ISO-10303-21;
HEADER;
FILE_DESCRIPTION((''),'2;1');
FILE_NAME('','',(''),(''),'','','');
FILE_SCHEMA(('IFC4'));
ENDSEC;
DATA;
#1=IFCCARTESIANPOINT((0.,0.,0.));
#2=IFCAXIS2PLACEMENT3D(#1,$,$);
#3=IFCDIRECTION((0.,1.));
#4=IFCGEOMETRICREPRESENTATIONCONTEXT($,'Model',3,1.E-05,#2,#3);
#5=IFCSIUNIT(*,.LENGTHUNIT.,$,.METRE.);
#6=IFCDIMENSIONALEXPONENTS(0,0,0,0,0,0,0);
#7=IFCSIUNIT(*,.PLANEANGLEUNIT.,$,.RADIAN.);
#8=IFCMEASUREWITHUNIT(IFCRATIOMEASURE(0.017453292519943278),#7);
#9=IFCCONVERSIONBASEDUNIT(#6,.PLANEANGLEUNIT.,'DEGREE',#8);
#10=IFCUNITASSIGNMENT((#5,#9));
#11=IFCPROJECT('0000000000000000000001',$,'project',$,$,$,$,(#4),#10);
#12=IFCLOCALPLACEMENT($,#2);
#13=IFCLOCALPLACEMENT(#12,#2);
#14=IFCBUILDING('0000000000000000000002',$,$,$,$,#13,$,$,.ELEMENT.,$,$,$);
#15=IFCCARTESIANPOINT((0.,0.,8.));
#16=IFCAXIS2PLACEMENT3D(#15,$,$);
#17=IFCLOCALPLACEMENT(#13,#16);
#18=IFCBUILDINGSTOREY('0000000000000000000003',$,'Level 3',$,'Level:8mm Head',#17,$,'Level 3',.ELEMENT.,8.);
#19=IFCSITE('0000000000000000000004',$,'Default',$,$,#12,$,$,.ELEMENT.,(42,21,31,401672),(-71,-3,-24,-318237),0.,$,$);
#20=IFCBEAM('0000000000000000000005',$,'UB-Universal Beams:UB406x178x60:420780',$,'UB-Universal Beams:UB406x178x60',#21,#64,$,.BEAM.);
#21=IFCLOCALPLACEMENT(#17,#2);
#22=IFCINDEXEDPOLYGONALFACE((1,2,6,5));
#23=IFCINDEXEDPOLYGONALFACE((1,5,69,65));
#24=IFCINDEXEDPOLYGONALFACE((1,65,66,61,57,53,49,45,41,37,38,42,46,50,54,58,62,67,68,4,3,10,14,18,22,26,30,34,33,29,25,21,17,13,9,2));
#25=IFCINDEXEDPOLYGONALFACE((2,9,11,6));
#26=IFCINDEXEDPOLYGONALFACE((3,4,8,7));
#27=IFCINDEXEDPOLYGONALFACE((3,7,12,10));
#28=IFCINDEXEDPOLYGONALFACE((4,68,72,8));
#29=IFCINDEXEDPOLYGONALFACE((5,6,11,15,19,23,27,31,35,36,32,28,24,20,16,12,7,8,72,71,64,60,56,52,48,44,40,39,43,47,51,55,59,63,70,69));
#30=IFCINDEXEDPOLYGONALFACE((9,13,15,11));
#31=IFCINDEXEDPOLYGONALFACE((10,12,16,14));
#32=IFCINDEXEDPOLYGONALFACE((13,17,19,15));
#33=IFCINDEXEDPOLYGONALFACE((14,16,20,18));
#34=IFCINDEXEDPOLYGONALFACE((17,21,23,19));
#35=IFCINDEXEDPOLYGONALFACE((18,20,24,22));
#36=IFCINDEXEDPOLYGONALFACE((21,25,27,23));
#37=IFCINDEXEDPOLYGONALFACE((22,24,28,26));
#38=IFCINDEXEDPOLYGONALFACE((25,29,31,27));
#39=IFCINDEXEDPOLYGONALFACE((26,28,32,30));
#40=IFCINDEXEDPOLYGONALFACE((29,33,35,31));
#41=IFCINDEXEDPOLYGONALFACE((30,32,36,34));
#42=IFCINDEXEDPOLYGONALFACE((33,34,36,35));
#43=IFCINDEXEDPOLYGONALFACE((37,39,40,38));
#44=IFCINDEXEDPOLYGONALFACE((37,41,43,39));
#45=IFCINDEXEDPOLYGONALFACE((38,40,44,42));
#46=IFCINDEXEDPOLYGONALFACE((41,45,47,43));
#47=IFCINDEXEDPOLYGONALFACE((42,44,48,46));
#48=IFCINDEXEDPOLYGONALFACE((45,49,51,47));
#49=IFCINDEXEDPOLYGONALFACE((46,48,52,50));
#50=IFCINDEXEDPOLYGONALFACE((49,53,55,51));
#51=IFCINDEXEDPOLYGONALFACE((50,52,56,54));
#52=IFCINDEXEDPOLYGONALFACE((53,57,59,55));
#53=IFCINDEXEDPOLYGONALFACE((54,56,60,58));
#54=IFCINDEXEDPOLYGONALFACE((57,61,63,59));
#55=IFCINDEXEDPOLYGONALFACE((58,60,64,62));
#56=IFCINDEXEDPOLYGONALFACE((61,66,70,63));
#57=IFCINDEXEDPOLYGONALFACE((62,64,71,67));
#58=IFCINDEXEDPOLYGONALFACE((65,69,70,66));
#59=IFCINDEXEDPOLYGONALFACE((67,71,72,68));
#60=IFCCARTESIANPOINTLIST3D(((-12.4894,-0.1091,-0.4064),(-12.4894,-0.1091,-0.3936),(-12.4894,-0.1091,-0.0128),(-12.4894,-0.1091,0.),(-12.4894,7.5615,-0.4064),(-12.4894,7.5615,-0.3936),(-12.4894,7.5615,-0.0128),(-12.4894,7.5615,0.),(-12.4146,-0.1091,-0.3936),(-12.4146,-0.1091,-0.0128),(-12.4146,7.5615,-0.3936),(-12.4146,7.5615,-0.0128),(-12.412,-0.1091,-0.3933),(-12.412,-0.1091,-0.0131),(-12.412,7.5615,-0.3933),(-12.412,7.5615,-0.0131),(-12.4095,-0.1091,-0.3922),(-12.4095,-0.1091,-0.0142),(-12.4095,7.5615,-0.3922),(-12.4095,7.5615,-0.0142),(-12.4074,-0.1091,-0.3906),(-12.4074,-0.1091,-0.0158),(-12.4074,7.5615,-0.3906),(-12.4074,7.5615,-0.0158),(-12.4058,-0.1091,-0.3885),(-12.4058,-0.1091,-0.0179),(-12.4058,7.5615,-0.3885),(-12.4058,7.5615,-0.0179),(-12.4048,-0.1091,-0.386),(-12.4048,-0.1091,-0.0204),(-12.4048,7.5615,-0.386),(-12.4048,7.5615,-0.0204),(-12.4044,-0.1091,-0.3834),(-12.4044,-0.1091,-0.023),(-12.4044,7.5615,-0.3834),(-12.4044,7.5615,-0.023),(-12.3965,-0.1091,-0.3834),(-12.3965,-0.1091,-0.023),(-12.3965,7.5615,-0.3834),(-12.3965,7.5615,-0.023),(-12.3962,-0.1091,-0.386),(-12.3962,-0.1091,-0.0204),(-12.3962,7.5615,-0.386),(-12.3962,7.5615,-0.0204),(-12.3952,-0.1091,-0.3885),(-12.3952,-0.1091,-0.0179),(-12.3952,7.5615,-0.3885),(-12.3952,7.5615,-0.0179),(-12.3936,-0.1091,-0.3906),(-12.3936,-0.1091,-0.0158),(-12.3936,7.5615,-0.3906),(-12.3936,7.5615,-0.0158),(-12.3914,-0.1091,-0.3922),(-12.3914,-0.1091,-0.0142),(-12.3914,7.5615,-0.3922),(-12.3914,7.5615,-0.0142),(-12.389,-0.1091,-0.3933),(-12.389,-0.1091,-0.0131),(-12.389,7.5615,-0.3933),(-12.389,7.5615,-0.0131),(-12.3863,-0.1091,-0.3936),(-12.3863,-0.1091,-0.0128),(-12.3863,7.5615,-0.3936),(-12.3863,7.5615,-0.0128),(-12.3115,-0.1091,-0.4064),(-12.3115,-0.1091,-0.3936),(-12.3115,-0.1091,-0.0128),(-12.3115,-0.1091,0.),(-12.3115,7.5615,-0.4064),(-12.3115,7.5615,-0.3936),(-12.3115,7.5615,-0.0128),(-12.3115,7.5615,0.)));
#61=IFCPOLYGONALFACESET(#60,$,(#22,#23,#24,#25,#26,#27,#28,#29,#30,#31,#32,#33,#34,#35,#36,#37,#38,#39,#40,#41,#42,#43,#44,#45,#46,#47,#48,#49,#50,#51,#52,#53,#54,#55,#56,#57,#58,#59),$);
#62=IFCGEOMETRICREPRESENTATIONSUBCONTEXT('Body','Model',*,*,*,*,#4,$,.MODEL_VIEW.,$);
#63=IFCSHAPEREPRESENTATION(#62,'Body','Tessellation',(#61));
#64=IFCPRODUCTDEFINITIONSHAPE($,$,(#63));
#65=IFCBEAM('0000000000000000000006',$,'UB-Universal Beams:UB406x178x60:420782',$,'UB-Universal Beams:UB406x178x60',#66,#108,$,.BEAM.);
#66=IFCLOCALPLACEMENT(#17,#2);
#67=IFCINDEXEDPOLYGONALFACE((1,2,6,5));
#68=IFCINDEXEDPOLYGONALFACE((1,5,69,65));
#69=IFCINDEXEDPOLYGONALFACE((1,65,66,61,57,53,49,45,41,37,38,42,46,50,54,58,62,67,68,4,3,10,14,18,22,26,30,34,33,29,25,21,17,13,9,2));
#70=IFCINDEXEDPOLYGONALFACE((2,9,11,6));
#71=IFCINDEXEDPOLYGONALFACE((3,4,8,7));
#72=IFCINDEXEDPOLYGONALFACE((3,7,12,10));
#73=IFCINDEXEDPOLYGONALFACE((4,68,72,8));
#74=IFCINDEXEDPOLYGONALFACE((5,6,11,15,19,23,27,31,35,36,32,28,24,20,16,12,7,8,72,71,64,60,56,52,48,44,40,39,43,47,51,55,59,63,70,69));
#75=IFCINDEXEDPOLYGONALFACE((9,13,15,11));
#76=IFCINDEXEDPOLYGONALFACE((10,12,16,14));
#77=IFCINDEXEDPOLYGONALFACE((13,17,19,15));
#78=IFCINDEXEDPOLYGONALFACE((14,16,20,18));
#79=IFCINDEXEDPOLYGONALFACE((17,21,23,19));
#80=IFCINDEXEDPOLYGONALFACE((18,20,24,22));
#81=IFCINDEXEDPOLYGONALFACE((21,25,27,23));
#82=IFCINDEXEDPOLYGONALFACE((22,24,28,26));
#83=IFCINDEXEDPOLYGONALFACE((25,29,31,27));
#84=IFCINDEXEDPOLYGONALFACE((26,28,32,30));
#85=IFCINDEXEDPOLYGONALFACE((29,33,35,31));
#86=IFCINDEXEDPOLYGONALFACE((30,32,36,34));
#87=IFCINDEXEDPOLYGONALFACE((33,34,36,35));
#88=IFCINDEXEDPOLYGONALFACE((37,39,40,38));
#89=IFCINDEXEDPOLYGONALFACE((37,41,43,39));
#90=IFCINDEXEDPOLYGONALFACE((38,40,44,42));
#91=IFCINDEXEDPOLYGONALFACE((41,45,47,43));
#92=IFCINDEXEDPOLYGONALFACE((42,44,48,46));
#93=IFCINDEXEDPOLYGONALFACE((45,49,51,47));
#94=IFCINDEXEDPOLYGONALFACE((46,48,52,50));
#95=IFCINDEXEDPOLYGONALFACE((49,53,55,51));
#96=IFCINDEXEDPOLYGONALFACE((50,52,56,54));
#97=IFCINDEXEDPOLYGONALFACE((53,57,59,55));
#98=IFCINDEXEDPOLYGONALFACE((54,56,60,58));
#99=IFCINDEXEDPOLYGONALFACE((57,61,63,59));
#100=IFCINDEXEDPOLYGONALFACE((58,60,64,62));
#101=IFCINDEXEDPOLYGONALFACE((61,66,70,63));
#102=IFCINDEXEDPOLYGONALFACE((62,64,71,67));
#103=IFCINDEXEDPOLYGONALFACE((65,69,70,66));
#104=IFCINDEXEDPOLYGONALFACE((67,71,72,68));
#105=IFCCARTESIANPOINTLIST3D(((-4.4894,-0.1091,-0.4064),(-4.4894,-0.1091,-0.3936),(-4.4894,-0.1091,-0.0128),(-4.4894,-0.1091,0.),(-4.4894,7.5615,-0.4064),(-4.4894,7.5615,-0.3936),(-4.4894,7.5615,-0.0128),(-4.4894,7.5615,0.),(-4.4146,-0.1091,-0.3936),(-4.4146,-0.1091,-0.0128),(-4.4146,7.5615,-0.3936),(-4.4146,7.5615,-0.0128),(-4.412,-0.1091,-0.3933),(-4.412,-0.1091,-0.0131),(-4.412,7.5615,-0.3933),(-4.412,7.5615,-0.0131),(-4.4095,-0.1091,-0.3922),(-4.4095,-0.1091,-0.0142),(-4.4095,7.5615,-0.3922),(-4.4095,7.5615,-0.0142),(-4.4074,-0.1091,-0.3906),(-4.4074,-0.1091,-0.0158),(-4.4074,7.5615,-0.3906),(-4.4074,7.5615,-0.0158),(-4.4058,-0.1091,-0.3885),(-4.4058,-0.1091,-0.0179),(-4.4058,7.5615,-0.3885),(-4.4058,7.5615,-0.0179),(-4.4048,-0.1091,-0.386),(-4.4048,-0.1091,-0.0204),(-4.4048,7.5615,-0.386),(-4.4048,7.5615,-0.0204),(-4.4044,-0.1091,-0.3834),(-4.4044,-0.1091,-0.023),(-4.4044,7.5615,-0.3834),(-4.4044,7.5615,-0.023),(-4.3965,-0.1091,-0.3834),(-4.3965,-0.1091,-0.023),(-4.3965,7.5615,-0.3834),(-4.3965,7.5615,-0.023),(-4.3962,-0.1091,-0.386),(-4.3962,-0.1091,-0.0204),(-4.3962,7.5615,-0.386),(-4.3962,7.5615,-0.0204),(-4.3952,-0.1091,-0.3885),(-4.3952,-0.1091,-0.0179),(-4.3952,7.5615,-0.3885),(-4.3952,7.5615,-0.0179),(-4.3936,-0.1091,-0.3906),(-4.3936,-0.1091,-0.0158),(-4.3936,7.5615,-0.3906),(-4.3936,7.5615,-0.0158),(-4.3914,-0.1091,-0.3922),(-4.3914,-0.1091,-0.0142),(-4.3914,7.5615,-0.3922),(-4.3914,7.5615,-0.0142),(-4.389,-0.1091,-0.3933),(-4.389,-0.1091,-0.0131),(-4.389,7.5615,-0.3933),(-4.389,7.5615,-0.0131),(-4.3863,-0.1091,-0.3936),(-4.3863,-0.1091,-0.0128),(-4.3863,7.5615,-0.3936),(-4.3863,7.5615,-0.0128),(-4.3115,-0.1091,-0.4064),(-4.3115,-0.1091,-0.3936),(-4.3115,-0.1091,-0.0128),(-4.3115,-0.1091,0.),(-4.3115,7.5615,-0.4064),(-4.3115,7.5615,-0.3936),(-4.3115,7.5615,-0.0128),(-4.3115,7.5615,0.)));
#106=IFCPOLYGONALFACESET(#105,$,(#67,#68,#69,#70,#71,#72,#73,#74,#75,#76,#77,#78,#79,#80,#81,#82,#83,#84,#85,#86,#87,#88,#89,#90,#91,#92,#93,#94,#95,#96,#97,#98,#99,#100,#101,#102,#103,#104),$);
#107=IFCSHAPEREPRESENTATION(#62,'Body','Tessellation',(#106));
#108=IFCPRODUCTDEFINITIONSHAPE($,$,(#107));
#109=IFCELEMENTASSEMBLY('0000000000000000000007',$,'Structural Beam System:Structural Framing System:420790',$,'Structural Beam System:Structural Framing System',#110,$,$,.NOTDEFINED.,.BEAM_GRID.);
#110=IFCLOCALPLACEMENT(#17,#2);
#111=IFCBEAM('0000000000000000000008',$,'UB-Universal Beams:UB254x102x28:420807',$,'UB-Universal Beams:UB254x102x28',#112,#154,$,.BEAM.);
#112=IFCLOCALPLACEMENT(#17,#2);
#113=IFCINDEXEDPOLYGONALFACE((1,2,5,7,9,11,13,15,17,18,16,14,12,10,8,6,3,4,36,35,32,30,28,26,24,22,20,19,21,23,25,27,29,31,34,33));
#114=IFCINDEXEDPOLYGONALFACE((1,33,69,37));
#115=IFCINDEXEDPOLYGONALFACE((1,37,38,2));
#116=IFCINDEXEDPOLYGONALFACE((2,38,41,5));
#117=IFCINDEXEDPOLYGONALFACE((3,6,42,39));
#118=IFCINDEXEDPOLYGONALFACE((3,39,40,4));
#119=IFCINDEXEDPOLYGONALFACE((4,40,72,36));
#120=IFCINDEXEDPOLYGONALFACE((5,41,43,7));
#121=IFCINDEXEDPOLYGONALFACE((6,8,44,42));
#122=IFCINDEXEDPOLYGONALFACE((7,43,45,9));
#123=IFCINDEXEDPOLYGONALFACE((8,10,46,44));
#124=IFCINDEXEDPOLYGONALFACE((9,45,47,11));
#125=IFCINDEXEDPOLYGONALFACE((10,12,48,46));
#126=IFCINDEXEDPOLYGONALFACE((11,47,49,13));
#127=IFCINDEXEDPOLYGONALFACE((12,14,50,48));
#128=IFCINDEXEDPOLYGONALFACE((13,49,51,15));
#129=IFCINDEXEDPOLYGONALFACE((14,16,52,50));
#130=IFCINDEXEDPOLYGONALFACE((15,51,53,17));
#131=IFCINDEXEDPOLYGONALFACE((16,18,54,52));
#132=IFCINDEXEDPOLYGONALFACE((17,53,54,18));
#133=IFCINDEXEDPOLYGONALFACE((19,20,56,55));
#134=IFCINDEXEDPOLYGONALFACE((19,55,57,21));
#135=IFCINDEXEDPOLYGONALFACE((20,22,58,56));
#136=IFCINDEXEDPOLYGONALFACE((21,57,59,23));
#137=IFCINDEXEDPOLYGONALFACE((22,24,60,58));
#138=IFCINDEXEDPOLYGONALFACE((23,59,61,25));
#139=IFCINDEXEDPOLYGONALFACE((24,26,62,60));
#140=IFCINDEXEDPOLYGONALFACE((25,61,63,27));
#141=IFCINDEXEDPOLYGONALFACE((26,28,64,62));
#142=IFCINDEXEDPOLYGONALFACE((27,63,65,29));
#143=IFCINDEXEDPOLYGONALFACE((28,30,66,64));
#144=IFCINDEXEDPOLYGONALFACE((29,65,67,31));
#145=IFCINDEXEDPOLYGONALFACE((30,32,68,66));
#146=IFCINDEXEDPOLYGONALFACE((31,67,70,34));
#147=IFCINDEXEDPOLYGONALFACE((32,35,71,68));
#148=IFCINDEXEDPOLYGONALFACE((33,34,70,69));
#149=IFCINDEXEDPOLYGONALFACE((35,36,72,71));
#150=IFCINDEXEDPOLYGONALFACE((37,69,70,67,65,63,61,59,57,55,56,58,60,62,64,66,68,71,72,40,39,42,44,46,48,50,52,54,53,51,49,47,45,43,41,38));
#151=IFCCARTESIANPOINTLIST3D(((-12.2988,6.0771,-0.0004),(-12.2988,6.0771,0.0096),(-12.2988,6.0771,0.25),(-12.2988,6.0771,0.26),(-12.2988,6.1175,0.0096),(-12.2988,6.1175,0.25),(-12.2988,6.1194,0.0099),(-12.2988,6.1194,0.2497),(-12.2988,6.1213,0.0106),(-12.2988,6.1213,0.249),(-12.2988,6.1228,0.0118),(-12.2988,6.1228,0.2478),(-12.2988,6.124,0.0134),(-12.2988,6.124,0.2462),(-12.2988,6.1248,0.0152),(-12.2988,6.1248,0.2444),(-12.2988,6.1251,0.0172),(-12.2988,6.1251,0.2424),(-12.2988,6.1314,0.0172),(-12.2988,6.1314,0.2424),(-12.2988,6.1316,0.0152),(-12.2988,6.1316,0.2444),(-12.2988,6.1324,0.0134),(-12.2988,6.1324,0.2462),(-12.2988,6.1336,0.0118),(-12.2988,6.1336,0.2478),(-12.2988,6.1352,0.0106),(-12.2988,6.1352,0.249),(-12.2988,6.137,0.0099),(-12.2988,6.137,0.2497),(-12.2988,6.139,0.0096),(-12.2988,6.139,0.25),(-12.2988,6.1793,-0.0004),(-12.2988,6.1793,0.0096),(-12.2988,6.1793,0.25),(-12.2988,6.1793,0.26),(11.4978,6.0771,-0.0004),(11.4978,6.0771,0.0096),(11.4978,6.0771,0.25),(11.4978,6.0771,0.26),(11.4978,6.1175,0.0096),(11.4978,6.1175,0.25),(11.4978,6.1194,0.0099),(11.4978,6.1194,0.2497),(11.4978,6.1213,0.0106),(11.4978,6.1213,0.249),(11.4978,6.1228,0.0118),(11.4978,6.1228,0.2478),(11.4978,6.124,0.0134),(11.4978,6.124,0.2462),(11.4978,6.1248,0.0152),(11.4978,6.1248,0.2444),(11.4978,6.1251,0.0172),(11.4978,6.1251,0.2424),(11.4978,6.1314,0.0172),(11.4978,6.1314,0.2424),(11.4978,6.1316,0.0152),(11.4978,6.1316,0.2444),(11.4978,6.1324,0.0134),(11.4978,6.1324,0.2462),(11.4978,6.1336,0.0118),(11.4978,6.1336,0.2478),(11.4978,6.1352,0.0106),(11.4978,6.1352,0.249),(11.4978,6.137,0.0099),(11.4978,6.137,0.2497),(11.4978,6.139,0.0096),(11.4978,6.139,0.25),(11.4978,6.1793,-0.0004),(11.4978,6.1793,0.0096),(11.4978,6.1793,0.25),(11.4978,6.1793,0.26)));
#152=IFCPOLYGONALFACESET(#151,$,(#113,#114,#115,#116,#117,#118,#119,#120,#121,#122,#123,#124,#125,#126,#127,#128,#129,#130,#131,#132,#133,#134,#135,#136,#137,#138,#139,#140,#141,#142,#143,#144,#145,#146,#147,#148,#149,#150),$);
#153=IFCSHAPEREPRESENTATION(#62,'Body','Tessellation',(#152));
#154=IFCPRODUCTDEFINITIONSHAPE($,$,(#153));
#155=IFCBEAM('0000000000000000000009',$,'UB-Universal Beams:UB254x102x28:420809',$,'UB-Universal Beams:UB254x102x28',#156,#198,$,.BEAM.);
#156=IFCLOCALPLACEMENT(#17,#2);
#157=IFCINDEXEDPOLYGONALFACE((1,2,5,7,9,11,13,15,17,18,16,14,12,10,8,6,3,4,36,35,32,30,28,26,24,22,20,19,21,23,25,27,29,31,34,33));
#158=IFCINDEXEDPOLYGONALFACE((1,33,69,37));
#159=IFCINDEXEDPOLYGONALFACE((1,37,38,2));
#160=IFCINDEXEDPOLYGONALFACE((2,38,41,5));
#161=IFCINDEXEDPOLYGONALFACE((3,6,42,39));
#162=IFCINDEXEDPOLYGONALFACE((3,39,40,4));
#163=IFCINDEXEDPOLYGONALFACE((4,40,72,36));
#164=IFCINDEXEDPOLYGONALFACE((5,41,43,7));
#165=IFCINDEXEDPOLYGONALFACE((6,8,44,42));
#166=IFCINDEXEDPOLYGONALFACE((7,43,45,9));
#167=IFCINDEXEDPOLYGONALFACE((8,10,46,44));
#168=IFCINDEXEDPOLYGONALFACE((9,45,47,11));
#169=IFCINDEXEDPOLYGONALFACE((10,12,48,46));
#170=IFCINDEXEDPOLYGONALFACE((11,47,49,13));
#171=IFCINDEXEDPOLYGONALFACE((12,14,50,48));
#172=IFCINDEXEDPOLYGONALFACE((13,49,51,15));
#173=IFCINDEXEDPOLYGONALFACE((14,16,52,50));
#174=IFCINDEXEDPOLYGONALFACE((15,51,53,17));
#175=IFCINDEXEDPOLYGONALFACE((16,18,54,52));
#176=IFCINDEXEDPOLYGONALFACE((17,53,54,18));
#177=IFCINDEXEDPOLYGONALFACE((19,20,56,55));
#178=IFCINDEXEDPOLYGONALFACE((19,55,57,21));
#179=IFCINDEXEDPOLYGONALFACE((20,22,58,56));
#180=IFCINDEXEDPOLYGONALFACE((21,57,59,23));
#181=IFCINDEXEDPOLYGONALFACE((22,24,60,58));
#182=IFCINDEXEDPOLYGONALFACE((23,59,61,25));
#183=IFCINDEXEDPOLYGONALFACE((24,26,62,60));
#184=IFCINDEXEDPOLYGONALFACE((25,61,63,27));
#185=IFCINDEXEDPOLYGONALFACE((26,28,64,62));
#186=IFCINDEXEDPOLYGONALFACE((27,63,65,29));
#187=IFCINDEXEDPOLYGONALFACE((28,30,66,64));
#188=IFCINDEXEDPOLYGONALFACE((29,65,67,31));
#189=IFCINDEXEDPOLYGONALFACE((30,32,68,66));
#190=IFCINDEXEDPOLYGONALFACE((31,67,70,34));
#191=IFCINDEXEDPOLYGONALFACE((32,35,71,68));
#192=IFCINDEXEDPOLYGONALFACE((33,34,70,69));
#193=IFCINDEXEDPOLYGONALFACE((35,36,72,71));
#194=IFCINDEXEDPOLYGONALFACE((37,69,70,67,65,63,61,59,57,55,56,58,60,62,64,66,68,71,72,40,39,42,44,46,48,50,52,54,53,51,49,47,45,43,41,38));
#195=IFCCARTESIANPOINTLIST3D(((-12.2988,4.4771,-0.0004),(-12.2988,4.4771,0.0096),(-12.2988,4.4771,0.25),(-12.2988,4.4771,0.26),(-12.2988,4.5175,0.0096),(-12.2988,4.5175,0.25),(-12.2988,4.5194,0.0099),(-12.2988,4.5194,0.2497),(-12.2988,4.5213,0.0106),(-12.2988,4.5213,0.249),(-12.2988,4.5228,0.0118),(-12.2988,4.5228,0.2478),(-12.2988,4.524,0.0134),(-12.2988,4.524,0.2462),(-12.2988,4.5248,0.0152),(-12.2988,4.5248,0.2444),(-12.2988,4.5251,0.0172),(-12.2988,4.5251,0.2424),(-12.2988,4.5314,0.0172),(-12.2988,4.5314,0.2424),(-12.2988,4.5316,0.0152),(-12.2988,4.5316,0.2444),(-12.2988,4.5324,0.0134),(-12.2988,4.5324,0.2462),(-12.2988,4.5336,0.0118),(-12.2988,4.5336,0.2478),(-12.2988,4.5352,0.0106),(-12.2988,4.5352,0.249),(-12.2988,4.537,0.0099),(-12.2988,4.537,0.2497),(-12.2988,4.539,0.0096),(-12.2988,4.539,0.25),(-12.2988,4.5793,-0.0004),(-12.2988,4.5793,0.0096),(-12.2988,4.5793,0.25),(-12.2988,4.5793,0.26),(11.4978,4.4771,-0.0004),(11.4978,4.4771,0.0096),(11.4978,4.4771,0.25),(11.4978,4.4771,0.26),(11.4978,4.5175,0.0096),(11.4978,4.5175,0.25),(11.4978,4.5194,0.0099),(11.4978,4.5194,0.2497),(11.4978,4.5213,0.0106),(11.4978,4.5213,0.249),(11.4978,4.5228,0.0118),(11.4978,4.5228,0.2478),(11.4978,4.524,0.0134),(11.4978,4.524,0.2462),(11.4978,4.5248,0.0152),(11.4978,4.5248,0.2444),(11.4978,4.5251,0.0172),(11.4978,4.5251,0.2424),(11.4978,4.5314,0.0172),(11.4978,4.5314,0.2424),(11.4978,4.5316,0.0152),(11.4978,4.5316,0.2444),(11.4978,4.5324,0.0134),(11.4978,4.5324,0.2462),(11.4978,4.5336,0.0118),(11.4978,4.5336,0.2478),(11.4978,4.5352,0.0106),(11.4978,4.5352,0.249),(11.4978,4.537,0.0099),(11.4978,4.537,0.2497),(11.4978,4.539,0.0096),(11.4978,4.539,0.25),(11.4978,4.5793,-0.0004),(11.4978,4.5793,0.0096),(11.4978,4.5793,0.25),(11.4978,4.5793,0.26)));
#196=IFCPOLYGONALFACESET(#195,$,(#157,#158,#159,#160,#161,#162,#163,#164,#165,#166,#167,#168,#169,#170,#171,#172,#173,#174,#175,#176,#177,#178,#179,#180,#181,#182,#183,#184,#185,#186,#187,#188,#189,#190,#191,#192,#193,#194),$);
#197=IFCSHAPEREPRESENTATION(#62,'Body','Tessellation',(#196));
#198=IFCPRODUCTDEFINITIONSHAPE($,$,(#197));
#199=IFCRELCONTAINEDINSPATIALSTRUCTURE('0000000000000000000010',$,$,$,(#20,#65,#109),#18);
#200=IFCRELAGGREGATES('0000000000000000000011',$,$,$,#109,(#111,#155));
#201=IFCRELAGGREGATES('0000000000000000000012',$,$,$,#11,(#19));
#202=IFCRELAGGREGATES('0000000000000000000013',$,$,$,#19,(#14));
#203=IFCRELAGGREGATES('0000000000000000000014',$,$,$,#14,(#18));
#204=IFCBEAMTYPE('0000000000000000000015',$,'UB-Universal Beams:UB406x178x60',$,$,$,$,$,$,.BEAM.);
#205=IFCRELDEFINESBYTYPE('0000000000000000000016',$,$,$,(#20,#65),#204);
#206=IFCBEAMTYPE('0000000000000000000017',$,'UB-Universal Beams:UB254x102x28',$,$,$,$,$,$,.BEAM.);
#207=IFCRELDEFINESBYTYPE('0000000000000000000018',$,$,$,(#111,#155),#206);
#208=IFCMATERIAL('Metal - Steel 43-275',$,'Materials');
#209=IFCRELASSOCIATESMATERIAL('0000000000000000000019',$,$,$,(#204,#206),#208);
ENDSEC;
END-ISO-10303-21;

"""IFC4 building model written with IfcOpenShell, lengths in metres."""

from ifc_helpers import new_model, entity, si_unit, converted_unit, direction, frame, frame_2d, origin, place, context, subcontext, project, spatial, i_section, extrude, source, transform, mapped, material, material_profile, profile_set, type_object, type_shapes, element, aggregate, save


model = new_model("IFC4")

# Units and contexts
model_context = context("Model", 3, precision=1e-05, world=origin(), true_north=direction((0.0, 1.0)))
body_context = subcontext(model_context, "Body", "Model", "MODEL_VIEW")
ifc_project = project(units=[si_unit("LENGTHUNIT", "METRE"), converted_unit("PLANEANGLEUNIT", "DEGREE", entity("IfcRatioMeasure", 0.017453292519943278), si_unit("PLANEANGLEUNIT", "RADIAN"), dimensions=[0, 0, 0, 0, 0, 0, 0])], contexts=[model_context])

# Site, building, storey
site_placement = place(None, origin())
site = spatial("IfcSite", under=ifc_project, at=site_placement, Name="Default", CompositionType="ELEMENT", RefLatitude=(42, 21, 31, 401672), RefLongitude=(-71, -3, -24, -318237), RefElevation=0.0)
building_placement = place(site_placement, origin())
building = spatial("IfcBuilding", under=site, at=building_placement, CompositionType="ELEMENT")
storey_placement = place(building_placement, frame((0.0, 0.0, 8.0)))
storey = spatial("IfcBuildingStorey", under=building, at=storey_placement, Name="Level 3", ObjectType="Level:8mm Head", LongName="Level 3", CompositionType="ELEMENT", Elevation=8.0)

# Beams
ifc_material_1 = material(Name="Metal - Steel 43-275", Category="Materials")
ifc_material_profile_1 = material_profile(ifc_material_1, i_section(OverallWidth=0.1779, OverallDepth=0.4064, WebThickness=0.0079, FlangeThickness=0.0128, FilletRadius=0.0102, at=frame_2d((0.0, 0.0), x_axis=(0.0, 1.0))), Name="UB406x178x60")
ifc_profile_set_1 = profile_set([ifc_material_profile_1], Name="UB406x178x60")
beam_type_1 = type_object("IfcBeamType", Name="UB-Universal Beams:UB406x178x60", PredefinedType="BEAM", material=ifc_profile_set_1)
shared_shape_1 = source(origin(), body_context, "Body", "SweptSolid", [
    extrude(i_section(OverallWidth=0.1779, OverallDepth=0.4064, WebThickness=0.0079, FlangeThickness=0.0128, FilletRadius=0.0102, at=frame_2d((0.0, 0.0), x_axis=(0.0, 1.0))), frame((-3.8373, 0.0, 0.0), z_axis=(1.0, 0.0, 0.0), x_axis=(0.0, 0.0, -1.0)), (0.0, 0.0, 1.0), 7.6706),
])
type_shapes(beam_type_1, [shared_shape_1])
for number, where, z_axis, x_axis, name in (
    (1, (-12.4005, 3.7282, -0.2032), (0.0, 0.0, 1.0), (0.0, 1.0, 0.0), "UB-Universal Beams:UB406x178x60:420780"),
    (2, (-4.4005, 3.7282, -0.2032), (0.0, 0.0, 1.0), (0.0, 1.0, 0.0), "UB-Universal Beams:UB406x178x60:420782"),
):
    element("IfcBeam", number, at=place(storey_placement, frame(where, z_axis=z_axis, x_axis=x_axis)), inside=storey, type_object=beam_type_1, Name=name, ObjectType="UB-Universal Beams:UB406x178x60", PredefinedType="BEAM", context=body_context, shape_type="MappedRepresentation", body=[
        mapped(shared_shape_1, transform((0.0, 0.0, 0.0), scale=1.0)),
    ])

# Element assembly, beams
assembly_placement = place(storey_placement, origin())
assembly = element("IfcElementAssembly", 3, at=assembly_placement, inside=storey, Name="Structural Beam System:Structural Framing System:420790", ObjectType="Structural Beam System:Structural Framing System", AssemblyPlace="NOTDEFINED", PredefinedType="BEAM_GRID")
ifc_material_profile_2 = material_profile(ifc_material_1, i_section(OverallWidth=0.1022, OverallDepth=0.2604, WebThickness=0.0063, FlangeThickness=0.01, FilletRadius=0.0076, at=frame_2d((0.0, 0.0), x_axis=(0.0, 1.0))), Name="UB254x102x28")
ifc_profile_set_2 = profile_set([ifc_material_profile_2], Name="UB254x102x28")
beam_type_2 = type_object("IfcBeamType", Name="UB-Universal Beams:UB254x102x28", PredefinedType="BEAM", material=ifc_profile_set_2)
shared_shape_2 = source(origin(), body_context, "Body", "SweptSolid", [
    extrude(i_section(OverallWidth=0.1022, OverallDepth=0.2604, WebThickness=0.0063, FlangeThickness=0.01, FilletRadius=0.0076, at=frame_2d((0.0, 0.0), x_axis=(0.0, 1.0))), frame((-11.8983, 0.0, 0.0), z_axis=(1.0, 0.0, 0.0), x_axis=(0.0, 0.0, -1.0)), (0.0, 0.0, 1.0), 23.7966),
])
type_shapes(beam_type_2, [shared_shape_2])
beam_1_placement = place(assembly_placement, frame((-0.4005, 6.1282, 0.1298)))
beam_1 = element("IfcBeam", 4, at=beam_1_placement, type_object=beam_type_2, Name="UB-Universal Beams:UB254x102x28:420807", ObjectType="UB-Universal Beams:UB254x102x28", PredefinedType="BEAM", context=body_context, shape_type="MappedRepresentation", body=[
    mapped(shared_shape_2, transform((0.0, 0.0, 0.0), scale=1.0)),
])
beam_2_placement = place(assembly_placement, frame((-0.4005, 4.5282, 0.1298)))
beam_2 = element("IfcBeam", 5, at=beam_2_placement, type_object=beam_type_2, Name="UB-Universal Beams:UB254x102x28:420809", ObjectType="UB-Universal Beams:UB254x102x28", PredefinedType="BEAM", context=body_context, shape_type="MappedRepresentation", body=[
    mapped(shared_shape_2, transform((0.0, 0.0, 0.0), scale=1.0)),
])
aggregate(assembly, [beam_1, beam_2])

save(model, "model.ifc")
